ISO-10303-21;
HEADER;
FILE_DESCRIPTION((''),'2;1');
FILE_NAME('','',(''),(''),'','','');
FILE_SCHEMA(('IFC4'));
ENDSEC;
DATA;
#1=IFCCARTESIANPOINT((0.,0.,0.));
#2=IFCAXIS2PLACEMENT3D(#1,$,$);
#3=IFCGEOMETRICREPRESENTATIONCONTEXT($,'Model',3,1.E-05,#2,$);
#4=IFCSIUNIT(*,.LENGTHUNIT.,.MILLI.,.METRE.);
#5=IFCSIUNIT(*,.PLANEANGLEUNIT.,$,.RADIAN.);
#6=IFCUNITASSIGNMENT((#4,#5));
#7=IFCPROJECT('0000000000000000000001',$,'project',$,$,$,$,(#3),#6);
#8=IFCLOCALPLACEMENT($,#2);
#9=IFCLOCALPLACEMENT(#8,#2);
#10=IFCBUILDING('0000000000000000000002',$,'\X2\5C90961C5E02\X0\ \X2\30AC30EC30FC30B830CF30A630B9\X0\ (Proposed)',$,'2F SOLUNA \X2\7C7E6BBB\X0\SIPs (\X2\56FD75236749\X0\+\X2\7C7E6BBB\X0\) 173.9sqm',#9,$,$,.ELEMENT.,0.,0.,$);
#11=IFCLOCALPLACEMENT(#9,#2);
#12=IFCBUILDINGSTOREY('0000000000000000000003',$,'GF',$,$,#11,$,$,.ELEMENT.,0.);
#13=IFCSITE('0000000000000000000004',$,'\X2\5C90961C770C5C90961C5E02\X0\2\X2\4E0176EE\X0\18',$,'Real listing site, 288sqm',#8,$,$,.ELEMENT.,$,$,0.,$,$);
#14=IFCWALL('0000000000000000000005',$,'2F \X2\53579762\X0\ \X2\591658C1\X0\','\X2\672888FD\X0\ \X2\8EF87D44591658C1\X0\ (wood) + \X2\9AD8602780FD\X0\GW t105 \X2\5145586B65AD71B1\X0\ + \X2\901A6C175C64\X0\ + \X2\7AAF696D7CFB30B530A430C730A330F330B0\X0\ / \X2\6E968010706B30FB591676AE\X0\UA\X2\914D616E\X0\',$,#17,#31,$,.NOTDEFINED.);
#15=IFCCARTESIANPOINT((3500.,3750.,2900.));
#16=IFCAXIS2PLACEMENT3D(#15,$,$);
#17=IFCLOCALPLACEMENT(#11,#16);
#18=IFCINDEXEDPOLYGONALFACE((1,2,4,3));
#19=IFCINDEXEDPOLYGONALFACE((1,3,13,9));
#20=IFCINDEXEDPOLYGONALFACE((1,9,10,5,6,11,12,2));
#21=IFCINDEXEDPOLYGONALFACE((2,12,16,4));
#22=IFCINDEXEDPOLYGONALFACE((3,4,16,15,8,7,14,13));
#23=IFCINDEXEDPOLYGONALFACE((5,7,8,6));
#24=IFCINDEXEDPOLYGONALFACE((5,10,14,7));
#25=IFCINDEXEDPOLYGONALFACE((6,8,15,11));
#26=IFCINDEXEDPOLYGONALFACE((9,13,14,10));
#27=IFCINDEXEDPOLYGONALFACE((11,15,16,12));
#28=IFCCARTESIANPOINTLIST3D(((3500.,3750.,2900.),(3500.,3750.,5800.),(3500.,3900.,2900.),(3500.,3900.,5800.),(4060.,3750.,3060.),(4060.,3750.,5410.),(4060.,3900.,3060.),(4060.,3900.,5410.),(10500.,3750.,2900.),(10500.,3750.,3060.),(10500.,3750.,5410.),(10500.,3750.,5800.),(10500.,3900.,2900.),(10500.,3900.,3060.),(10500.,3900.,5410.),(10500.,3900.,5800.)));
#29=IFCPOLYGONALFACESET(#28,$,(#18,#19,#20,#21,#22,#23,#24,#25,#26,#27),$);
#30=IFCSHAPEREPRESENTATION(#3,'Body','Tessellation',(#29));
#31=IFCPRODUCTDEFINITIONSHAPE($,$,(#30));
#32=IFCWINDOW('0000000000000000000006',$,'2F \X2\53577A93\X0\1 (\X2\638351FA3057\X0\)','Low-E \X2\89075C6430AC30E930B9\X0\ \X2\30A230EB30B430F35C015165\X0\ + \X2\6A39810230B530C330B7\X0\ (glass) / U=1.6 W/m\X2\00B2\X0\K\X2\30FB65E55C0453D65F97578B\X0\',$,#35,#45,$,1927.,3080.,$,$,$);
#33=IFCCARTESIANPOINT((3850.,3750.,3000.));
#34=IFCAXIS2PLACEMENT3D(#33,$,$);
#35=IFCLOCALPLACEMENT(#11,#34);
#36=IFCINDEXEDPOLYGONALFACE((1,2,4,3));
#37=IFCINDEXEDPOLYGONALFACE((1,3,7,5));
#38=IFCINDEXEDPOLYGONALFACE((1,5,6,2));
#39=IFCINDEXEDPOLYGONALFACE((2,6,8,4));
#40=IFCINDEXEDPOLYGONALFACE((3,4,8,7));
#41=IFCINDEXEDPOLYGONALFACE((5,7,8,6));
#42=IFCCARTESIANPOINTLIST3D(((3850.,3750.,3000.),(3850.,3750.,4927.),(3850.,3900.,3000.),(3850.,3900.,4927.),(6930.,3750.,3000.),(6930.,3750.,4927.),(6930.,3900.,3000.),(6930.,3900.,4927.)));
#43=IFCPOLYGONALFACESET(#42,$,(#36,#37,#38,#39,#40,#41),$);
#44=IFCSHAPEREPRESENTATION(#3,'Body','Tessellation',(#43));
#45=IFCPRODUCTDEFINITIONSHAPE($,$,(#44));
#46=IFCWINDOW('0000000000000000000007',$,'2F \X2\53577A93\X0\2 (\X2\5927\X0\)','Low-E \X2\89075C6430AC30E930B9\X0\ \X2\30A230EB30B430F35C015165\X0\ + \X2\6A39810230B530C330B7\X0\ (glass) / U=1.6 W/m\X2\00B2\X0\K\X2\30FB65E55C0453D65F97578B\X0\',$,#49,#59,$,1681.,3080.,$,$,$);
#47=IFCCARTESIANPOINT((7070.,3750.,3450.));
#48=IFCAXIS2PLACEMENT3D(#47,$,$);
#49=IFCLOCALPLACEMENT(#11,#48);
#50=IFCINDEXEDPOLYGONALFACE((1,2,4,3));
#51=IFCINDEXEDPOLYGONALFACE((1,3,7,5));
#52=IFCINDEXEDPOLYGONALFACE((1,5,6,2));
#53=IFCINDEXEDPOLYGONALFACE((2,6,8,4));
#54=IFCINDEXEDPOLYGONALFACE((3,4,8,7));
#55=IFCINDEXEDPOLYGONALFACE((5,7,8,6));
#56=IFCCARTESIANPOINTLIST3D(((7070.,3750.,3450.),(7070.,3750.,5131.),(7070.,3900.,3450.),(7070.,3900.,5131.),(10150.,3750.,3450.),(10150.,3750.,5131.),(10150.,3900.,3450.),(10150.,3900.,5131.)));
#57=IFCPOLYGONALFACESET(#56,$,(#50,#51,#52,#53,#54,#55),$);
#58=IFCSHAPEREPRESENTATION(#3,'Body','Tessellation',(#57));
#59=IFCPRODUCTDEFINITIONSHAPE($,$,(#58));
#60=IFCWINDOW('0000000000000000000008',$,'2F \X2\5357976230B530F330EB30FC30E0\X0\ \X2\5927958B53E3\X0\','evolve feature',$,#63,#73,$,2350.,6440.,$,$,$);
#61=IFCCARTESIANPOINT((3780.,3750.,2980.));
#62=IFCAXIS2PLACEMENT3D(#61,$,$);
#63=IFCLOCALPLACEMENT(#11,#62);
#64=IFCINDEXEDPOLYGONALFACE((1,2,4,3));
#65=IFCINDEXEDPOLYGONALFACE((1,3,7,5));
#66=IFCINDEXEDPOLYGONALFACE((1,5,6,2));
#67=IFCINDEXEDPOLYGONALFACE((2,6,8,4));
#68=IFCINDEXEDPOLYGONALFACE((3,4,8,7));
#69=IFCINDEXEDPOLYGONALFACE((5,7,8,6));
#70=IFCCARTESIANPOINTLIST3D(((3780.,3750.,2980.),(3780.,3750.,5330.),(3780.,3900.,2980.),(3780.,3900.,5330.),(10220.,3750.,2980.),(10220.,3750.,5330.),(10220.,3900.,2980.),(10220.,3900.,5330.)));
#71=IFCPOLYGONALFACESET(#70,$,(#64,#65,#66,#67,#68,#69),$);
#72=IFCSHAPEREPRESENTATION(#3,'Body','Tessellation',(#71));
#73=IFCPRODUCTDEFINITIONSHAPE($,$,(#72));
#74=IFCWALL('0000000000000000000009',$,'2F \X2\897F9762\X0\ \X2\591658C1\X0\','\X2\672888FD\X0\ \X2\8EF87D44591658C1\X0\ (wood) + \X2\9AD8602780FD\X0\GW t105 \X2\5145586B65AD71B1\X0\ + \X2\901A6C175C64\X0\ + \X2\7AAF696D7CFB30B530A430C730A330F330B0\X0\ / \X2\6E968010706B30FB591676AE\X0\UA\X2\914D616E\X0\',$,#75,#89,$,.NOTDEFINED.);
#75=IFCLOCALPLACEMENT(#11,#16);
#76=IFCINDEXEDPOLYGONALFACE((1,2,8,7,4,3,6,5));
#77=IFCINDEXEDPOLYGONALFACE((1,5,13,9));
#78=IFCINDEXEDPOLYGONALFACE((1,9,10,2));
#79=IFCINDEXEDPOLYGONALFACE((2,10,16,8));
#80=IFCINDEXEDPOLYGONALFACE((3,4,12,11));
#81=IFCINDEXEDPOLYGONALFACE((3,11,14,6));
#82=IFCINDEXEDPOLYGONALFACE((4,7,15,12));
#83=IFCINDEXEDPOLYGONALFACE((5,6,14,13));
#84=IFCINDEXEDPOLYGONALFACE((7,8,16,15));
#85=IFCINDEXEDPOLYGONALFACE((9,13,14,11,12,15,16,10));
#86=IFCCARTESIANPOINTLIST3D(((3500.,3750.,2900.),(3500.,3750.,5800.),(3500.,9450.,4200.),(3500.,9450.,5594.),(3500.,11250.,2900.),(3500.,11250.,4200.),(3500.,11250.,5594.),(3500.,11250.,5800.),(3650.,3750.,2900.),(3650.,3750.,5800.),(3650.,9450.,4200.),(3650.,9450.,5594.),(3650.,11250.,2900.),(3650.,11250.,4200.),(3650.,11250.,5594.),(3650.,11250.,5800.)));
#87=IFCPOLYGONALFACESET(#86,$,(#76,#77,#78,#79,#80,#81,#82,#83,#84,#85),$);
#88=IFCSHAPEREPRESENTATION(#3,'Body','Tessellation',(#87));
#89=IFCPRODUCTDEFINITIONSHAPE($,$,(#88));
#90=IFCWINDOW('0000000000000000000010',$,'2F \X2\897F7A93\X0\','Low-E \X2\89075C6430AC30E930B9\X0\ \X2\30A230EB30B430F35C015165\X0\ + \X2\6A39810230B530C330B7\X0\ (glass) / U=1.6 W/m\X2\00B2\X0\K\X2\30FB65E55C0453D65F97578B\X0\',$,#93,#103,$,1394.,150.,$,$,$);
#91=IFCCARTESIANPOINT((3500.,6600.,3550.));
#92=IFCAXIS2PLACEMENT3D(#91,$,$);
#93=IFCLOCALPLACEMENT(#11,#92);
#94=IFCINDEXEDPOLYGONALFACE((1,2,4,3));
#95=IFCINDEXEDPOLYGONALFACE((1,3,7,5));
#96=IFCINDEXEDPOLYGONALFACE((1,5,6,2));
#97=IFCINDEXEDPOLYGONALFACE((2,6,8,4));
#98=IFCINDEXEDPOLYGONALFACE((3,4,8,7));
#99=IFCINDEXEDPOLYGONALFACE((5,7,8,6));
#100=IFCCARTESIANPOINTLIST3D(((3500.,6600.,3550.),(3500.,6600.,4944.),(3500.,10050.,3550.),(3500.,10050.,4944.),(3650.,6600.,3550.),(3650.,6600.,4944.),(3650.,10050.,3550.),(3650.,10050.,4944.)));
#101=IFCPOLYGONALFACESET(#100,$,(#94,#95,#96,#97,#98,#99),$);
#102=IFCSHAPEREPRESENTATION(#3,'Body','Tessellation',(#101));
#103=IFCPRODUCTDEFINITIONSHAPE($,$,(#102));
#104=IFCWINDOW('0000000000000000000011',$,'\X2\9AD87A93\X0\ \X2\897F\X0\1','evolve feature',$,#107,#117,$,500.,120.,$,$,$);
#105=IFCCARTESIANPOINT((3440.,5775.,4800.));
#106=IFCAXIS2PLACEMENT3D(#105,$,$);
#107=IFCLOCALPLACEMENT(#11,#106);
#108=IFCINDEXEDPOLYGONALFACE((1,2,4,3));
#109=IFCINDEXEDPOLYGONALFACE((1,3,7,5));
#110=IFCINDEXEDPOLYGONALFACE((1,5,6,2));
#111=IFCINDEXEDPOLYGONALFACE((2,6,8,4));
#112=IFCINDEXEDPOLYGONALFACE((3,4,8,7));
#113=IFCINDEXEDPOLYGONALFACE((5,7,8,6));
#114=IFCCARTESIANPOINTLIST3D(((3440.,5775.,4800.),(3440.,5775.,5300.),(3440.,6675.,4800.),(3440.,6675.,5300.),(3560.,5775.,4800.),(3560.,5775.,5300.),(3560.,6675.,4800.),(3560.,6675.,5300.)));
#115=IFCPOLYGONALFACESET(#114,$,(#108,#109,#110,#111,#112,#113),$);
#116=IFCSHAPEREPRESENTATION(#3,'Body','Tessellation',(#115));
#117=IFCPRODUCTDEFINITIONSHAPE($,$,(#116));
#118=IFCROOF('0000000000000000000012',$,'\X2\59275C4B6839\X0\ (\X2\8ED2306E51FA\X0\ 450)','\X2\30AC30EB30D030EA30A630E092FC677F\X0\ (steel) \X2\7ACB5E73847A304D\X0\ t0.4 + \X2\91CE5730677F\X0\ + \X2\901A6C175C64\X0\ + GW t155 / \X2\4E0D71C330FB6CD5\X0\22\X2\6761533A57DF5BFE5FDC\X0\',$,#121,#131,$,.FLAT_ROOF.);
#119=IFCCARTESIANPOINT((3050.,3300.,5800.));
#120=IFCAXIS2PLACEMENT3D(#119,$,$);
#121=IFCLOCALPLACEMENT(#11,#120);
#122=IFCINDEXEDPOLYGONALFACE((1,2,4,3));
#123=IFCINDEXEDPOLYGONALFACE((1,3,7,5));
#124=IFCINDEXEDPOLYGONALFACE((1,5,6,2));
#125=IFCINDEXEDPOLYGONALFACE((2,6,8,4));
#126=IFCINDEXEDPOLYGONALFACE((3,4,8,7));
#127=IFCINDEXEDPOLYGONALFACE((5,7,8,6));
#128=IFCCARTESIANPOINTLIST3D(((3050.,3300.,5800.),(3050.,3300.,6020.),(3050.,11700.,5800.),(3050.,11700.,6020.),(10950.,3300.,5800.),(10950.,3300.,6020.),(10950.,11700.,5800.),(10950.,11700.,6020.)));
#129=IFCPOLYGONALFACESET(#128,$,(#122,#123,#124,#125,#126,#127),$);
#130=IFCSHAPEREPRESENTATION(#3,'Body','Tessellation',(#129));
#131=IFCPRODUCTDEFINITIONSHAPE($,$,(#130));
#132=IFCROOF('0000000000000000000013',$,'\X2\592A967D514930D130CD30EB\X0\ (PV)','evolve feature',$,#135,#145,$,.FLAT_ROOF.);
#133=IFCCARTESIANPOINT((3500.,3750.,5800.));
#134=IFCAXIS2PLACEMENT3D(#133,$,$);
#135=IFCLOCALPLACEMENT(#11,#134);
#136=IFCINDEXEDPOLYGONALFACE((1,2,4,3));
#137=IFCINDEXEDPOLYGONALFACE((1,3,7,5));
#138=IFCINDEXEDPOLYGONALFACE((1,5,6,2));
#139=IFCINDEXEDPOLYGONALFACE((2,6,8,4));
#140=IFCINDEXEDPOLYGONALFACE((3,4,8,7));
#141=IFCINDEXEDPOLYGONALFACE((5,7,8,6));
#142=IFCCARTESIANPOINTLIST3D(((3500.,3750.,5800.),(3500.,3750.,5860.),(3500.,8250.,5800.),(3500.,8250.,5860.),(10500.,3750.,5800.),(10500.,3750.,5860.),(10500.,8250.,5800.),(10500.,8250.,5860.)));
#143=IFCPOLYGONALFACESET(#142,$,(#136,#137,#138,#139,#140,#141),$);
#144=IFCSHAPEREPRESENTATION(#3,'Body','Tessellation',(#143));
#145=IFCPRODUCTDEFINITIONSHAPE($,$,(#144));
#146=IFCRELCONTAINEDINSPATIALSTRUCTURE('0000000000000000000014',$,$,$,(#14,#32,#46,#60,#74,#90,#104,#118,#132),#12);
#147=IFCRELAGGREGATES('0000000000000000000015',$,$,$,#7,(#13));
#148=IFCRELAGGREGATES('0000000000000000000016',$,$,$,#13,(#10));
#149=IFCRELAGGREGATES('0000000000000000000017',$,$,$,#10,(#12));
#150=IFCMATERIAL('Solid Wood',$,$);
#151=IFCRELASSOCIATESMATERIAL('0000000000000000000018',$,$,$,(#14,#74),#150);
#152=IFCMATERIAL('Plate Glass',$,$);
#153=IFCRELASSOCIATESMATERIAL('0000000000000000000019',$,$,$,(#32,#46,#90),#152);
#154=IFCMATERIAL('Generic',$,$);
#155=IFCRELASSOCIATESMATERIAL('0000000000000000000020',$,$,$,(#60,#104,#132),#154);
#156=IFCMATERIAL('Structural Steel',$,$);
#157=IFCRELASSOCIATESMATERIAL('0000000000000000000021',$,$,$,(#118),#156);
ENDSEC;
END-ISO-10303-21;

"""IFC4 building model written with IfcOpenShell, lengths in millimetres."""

from ifc_helpers import new_model, si_unit, frame, frame_2d, origin, place, context, project, spatial, rectangle, extrude, material, element, fill, save


model = new_model("IFC4")

# Units and contexts
model_context = context("Model", 3, precision=1e-05, world=origin())
ifc_project = project(units=[si_unit("LENGTHUNIT", "METRE", prefix="MILLI"), si_unit("PLANEANGLEUNIT", "RADIAN")], contexts=[model_context])

# Site, building, storey
site_placement = place(None, origin())
site = spatial("IfcSite", under=ifc_project, at=site_placement, Name="岐阜県岐阜市2丁目18", ObjectType="Real listing site, 288sqm", CompositionType="ELEMENT", RefElevation=0.0)
building_placement = place(site_placement, origin())
building = spatial("IfcBuilding", under=site, at=building_placement, Name="岐阜市 ガレージハウス (Proposed)", ObjectType="2F SOLUNA 籾殻SIPs (国産杉+籾殻) 173.9sqm", CompositionType="ELEMENT", ElevationOfRefHeight=0.0, ElevationOfTerrain=0.0)
storey_placement = place(building_placement, origin())
storey = spatial("IfcBuildingStorey", under=building, at=storey_placement, Name="GF", CompositionType="ELEMENT", Elevation=0.0)

# Shared definitions
ifc_material_1 = material(Name="Solid Wood")
ifc_material_2 = material(Name="Generic")

# Shared definitions
ifc_material_3 = material(Name="Plate Glass")

# Walls, openings, windows
wall_1_placement = place(storey_placement, frame((3500.0, 3750.0, 2900.0)))
wall_1 = element("IfcWall", 1, at=wall_1_placement, inside=storey, material=ifc_material_1, Name="2F 南面 外壁", Description="木製 軸組外壁 (wood) + 高性能GW t105 充填断熱 + 通気層 + 窯業系サイディング / 準耐火・外皮UA配慮", PredefinedType="NOTDEFINED", context=model_context, shape_type="SweptSolid", body=[
    extrude(rectangle(XDim=7000.0, YDim=150.0, at=frame_2d((3500.0, 75.0))), frame((3500.0, 3750.0, 2900.0)), (0.0, 0.0, 1.0), 2900.0),
])
opening_1_placement = place(storey_placement, frame((3850.0, 3750.0, 3000.0)))
opening_1 = element("IfcOpeningElement", 2, at=opening_1_placement, cuts=wall_1, PredefinedType="NOTDEFINED", context=model_context, shape_type="SweptSolid", body=[
    extrude(rectangle(XDim=3080.0, YDim=150.0, at=frame_2d((1540.0, 75.0))), frame((3850.0, 3750.0, 3000.0)), (0.0, 0.0, 1.0), 1927.0),
])
opening_2_placement = place(storey_placement, frame((7070.0, 3750.0, 3450.0)))
opening_2 = element("IfcOpeningElement", 3, at=opening_2_placement, cuts=wall_1, PredefinedType="NOTDEFINED", context=model_context, shape_type="SweptSolid", body=[
    extrude(rectangle(XDim=3080.0, YDim=150.0, at=frame_2d((1540.0, 75.0))), frame((7070.0, 3750.0, 3450.0)), (0.0, 0.0, 1.0), 1681.0),
])
opening_3_placement = place(storey_placement, frame((3780.0, 3750.0, 2980.0)))
opening_3 = element("IfcOpeningElement", 4, at=opening_3_placement, cuts=wall_1, PredefinedType="NOTDEFINED", context=model_context, shape_type="SweptSolid", body=[
    extrude(rectangle(XDim=6440.0, YDim=150.0, at=frame_2d((3220.0, 75.0))), frame((3780.0, 3750.0, 2980.0)), (0.0, 0.0, 1.0), 2350.0),
])
window_1_placement = place(storey_placement, frame((3850.0, 3750.0, 3000.0)))
window_1 = element("IfcWindow", 5, at=window_1_placement, inside=storey, material=ifc_material_3, Name="2F 南窓1 (掃出し)", Description="Low-E 複層ガラス アルゴン封入 + 樹脂サッシ (glass) / U=1.6 W/m²K・日射取得型", OverallHeight=1927.0, OverallWidth=3080.0, context=model_context, shape_type="SweptSolid", body=[
    extrude(rectangle(XDim=3080.0, YDim=150.0, at=frame_2d((1540.0, 75.0))), frame((3850.0, 3750.0, 3000.0)), (0.0, 0.0, 1.0), 1927.0),
])
fill(opening_1, window_1)
window_2_placement = place(storey_placement, frame((7070.0, 3750.0, 3450.0)))
window_2 = element("IfcWindow", 6, at=window_2_placement, inside=storey, material=ifc_material_3, Name="2F 南窓2 (大)", Description="Low-E 複層ガラス アルゴン封入 + 樹脂サッシ (glass) / U=1.6 W/m²K・日射取得型", OverallHeight=1681.0, OverallWidth=3080.0, context=model_context, shape_type="SweptSolid", body=[
    extrude(rectangle(XDim=3080.0, YDim=150.0, at=frame_2d((1540.0, 75.0))), frame((7070.0, 3750.0, 3450.0)), (0.0, 0.0, 1.0), 1681.0),
])
fill(opening_2, window_2)
window_3_placement = place(storey_placement, frame((3780.0, 3750.0, 2980.0)))
window_3 = element("IfcWindow", 7, at=window_3_placement, inside=storey, material=ifc_material_2, Name="2F 南面サンルーム 大開口", Description="evolve feature", OverallHeight=2350.0, OverallWidth=6440.0, context=model_context, shape_type="SweptSolid", body=[
    extrude(rectangle(XDim=6440.0, YDim=150.0, at=frame_2d((3220.0, 75.0))), frame((3780.0, 3750.0, 2980.0)), (0.0, 0.0, 1.0), 2350.0),
])
fill(opening_3, window_3)
wall_2_placement = place(storey_placement, frame((3500.0, 3750.0, 2900.0)))
wall_2 = element("IfcWall", 8, at=wall_2_placement, inside=storey, material=ifc_material_1, Name="2F 西面 外壁", Description="木製 軸組外壁 (wood) + 高性能GW t105 充填断熱 + 通気層 + 窯業系サイディング / 準耐火・外皮UA配慮", PredefinedType="NOTDEFINED", context=model_context, shape_type="SweptSolid", body=[
    extrude(rectangle(XDim=150.0, YDim=7500.0, at=frame_2d((75.0, 3750.0))), frame((3500.0, 3750.0, 2900.0)), (0.0, 0.0, 1.0), 2900.0),
])
opening_4_placement = place(storey_placement, frame((3500.0, 6600.0, 3550.0)))
opening_4 = element("IfcOpeningElement", 9, at=opening_4_placement, cuts=wall_2, PredefinedType="NOTDEFINED", context=model_context, shape_type="SweptSolid", body=[
    extrude(rectangle(XDim=150.0, YDim=3450.0, at=frame_2d((75.0, 1725.0))), frame((3500.0, 6600.0, 3550.0)), (0.0, 0.0, 1.0), 1394.0),
])
opening_5_placement = place(storey_placement, frame((3440.0, 5775.0, 4800.0)))
opening_5 = element("IfcOpeningElement", 10, at=opening_5_placement, cuts=wall_2, PredefinedType="NOTDEFINED", context=model_context, shape_type="SweptSolid", body=[
    extrude(rectangle(XDim=120.0, YDim=900.0, at=frame_2d((60.0, 450.0))), frame((3440.0, 5775.0, 4800.0)), (0.0, 0.0, 1.0), 500.0),
])
window_4_placement = place(storey_placement, frame((3500.0, 6600.0, 3550.0)))
window_4 = element("IfcWindow", 11, at=window_4_placement, inside=storey, material=ifc_material_3, Name="2F 西窓", Description="Low-E 複層ガラス アルゴン封入 + 樹脂サッシ (glass) / U=1.6 W/m²K・日射取得型", OverallHeight=1394.0, OverallWidth=150.0, context=model_context, shape_type="SweptSolid", body=[
    extrude(rectangle(XDim=150.0, YDim=3450.0, at=frame_2d((75.0, 1725.0))), frame((3500.0, 6600.0, 3550.0)), (0.0, 0.0, 1.0), 1394.0),
])
fill(opening_4, window_4)
window_5_placement = place(storey_placement, frame((3440.0, 5775.0, 4800.0)))
window_5 = element("IfcWindow", 12, at=window_5_placement, inside=storey, material=ifc_material_2, Name="高窓 西1", Description="evolve feature", OverallHeight=500.0, OverallWidth=120.0, context=model_context, shape_type="SweptSolid", body=[
    extrude(rectangle(XDim=120.0, YDim=900.0, at=frame_2d((60.0, 450.0))), frame((3440.0, 5775.0, 4800.0)), (0.0, 0.0, 1.0), 500.0),
])
fill(opening_5, window_5)

# Roofs
ifc_material_4 = material(Name="Structural Steel")
roof_1_placement = place(storey_placement, frame((3050.0, 3300.0, 5800.0)))
element("IfcRoof", 13, at=roof_1_placement, inside=storey, material=ifc_material_4, Name="大屋根 (軒の出 450)", Description="ガルバリウム鋼板 (steel) 立平葺き t0.4 + 野地板 + 通気層 + GW t155 / 不燃・法22条区域対応", PredefinedType="FLAT_ROOF", context=model_context, shape_type="SweptSolid", body=[
    extrude(rectangle(XDim=7900.0, YDim=8400.0, at=frame_2d((3950.0, 4200.0))), frame((3050.0, 3300.0, 5800.0)), (0.0, 0.0, 1.0), 220.0),
])
roof_2_placement = place(storey_placement, frame((3500.0, 3750.0, 5800.0)))
element("IfcRoof", 14, at=roof_2_placement, inside=storey, material=ifc_material_2, Name="太陽光パネル (PV)", Description="evolve feature", PredefinedType="FLAT_ROOF", context=model_context, shape_type="SweptSolid", body=[
    extrude(rectangle(XDim=7000.0, YDim=4500.0, at=frame_2d((3500.0, 2250.0))), frame((3500.0, 3750.0, 5800.0)), (0.0, 0.0, 1.0), 60.0),
])

save(model, "model.ifc")
